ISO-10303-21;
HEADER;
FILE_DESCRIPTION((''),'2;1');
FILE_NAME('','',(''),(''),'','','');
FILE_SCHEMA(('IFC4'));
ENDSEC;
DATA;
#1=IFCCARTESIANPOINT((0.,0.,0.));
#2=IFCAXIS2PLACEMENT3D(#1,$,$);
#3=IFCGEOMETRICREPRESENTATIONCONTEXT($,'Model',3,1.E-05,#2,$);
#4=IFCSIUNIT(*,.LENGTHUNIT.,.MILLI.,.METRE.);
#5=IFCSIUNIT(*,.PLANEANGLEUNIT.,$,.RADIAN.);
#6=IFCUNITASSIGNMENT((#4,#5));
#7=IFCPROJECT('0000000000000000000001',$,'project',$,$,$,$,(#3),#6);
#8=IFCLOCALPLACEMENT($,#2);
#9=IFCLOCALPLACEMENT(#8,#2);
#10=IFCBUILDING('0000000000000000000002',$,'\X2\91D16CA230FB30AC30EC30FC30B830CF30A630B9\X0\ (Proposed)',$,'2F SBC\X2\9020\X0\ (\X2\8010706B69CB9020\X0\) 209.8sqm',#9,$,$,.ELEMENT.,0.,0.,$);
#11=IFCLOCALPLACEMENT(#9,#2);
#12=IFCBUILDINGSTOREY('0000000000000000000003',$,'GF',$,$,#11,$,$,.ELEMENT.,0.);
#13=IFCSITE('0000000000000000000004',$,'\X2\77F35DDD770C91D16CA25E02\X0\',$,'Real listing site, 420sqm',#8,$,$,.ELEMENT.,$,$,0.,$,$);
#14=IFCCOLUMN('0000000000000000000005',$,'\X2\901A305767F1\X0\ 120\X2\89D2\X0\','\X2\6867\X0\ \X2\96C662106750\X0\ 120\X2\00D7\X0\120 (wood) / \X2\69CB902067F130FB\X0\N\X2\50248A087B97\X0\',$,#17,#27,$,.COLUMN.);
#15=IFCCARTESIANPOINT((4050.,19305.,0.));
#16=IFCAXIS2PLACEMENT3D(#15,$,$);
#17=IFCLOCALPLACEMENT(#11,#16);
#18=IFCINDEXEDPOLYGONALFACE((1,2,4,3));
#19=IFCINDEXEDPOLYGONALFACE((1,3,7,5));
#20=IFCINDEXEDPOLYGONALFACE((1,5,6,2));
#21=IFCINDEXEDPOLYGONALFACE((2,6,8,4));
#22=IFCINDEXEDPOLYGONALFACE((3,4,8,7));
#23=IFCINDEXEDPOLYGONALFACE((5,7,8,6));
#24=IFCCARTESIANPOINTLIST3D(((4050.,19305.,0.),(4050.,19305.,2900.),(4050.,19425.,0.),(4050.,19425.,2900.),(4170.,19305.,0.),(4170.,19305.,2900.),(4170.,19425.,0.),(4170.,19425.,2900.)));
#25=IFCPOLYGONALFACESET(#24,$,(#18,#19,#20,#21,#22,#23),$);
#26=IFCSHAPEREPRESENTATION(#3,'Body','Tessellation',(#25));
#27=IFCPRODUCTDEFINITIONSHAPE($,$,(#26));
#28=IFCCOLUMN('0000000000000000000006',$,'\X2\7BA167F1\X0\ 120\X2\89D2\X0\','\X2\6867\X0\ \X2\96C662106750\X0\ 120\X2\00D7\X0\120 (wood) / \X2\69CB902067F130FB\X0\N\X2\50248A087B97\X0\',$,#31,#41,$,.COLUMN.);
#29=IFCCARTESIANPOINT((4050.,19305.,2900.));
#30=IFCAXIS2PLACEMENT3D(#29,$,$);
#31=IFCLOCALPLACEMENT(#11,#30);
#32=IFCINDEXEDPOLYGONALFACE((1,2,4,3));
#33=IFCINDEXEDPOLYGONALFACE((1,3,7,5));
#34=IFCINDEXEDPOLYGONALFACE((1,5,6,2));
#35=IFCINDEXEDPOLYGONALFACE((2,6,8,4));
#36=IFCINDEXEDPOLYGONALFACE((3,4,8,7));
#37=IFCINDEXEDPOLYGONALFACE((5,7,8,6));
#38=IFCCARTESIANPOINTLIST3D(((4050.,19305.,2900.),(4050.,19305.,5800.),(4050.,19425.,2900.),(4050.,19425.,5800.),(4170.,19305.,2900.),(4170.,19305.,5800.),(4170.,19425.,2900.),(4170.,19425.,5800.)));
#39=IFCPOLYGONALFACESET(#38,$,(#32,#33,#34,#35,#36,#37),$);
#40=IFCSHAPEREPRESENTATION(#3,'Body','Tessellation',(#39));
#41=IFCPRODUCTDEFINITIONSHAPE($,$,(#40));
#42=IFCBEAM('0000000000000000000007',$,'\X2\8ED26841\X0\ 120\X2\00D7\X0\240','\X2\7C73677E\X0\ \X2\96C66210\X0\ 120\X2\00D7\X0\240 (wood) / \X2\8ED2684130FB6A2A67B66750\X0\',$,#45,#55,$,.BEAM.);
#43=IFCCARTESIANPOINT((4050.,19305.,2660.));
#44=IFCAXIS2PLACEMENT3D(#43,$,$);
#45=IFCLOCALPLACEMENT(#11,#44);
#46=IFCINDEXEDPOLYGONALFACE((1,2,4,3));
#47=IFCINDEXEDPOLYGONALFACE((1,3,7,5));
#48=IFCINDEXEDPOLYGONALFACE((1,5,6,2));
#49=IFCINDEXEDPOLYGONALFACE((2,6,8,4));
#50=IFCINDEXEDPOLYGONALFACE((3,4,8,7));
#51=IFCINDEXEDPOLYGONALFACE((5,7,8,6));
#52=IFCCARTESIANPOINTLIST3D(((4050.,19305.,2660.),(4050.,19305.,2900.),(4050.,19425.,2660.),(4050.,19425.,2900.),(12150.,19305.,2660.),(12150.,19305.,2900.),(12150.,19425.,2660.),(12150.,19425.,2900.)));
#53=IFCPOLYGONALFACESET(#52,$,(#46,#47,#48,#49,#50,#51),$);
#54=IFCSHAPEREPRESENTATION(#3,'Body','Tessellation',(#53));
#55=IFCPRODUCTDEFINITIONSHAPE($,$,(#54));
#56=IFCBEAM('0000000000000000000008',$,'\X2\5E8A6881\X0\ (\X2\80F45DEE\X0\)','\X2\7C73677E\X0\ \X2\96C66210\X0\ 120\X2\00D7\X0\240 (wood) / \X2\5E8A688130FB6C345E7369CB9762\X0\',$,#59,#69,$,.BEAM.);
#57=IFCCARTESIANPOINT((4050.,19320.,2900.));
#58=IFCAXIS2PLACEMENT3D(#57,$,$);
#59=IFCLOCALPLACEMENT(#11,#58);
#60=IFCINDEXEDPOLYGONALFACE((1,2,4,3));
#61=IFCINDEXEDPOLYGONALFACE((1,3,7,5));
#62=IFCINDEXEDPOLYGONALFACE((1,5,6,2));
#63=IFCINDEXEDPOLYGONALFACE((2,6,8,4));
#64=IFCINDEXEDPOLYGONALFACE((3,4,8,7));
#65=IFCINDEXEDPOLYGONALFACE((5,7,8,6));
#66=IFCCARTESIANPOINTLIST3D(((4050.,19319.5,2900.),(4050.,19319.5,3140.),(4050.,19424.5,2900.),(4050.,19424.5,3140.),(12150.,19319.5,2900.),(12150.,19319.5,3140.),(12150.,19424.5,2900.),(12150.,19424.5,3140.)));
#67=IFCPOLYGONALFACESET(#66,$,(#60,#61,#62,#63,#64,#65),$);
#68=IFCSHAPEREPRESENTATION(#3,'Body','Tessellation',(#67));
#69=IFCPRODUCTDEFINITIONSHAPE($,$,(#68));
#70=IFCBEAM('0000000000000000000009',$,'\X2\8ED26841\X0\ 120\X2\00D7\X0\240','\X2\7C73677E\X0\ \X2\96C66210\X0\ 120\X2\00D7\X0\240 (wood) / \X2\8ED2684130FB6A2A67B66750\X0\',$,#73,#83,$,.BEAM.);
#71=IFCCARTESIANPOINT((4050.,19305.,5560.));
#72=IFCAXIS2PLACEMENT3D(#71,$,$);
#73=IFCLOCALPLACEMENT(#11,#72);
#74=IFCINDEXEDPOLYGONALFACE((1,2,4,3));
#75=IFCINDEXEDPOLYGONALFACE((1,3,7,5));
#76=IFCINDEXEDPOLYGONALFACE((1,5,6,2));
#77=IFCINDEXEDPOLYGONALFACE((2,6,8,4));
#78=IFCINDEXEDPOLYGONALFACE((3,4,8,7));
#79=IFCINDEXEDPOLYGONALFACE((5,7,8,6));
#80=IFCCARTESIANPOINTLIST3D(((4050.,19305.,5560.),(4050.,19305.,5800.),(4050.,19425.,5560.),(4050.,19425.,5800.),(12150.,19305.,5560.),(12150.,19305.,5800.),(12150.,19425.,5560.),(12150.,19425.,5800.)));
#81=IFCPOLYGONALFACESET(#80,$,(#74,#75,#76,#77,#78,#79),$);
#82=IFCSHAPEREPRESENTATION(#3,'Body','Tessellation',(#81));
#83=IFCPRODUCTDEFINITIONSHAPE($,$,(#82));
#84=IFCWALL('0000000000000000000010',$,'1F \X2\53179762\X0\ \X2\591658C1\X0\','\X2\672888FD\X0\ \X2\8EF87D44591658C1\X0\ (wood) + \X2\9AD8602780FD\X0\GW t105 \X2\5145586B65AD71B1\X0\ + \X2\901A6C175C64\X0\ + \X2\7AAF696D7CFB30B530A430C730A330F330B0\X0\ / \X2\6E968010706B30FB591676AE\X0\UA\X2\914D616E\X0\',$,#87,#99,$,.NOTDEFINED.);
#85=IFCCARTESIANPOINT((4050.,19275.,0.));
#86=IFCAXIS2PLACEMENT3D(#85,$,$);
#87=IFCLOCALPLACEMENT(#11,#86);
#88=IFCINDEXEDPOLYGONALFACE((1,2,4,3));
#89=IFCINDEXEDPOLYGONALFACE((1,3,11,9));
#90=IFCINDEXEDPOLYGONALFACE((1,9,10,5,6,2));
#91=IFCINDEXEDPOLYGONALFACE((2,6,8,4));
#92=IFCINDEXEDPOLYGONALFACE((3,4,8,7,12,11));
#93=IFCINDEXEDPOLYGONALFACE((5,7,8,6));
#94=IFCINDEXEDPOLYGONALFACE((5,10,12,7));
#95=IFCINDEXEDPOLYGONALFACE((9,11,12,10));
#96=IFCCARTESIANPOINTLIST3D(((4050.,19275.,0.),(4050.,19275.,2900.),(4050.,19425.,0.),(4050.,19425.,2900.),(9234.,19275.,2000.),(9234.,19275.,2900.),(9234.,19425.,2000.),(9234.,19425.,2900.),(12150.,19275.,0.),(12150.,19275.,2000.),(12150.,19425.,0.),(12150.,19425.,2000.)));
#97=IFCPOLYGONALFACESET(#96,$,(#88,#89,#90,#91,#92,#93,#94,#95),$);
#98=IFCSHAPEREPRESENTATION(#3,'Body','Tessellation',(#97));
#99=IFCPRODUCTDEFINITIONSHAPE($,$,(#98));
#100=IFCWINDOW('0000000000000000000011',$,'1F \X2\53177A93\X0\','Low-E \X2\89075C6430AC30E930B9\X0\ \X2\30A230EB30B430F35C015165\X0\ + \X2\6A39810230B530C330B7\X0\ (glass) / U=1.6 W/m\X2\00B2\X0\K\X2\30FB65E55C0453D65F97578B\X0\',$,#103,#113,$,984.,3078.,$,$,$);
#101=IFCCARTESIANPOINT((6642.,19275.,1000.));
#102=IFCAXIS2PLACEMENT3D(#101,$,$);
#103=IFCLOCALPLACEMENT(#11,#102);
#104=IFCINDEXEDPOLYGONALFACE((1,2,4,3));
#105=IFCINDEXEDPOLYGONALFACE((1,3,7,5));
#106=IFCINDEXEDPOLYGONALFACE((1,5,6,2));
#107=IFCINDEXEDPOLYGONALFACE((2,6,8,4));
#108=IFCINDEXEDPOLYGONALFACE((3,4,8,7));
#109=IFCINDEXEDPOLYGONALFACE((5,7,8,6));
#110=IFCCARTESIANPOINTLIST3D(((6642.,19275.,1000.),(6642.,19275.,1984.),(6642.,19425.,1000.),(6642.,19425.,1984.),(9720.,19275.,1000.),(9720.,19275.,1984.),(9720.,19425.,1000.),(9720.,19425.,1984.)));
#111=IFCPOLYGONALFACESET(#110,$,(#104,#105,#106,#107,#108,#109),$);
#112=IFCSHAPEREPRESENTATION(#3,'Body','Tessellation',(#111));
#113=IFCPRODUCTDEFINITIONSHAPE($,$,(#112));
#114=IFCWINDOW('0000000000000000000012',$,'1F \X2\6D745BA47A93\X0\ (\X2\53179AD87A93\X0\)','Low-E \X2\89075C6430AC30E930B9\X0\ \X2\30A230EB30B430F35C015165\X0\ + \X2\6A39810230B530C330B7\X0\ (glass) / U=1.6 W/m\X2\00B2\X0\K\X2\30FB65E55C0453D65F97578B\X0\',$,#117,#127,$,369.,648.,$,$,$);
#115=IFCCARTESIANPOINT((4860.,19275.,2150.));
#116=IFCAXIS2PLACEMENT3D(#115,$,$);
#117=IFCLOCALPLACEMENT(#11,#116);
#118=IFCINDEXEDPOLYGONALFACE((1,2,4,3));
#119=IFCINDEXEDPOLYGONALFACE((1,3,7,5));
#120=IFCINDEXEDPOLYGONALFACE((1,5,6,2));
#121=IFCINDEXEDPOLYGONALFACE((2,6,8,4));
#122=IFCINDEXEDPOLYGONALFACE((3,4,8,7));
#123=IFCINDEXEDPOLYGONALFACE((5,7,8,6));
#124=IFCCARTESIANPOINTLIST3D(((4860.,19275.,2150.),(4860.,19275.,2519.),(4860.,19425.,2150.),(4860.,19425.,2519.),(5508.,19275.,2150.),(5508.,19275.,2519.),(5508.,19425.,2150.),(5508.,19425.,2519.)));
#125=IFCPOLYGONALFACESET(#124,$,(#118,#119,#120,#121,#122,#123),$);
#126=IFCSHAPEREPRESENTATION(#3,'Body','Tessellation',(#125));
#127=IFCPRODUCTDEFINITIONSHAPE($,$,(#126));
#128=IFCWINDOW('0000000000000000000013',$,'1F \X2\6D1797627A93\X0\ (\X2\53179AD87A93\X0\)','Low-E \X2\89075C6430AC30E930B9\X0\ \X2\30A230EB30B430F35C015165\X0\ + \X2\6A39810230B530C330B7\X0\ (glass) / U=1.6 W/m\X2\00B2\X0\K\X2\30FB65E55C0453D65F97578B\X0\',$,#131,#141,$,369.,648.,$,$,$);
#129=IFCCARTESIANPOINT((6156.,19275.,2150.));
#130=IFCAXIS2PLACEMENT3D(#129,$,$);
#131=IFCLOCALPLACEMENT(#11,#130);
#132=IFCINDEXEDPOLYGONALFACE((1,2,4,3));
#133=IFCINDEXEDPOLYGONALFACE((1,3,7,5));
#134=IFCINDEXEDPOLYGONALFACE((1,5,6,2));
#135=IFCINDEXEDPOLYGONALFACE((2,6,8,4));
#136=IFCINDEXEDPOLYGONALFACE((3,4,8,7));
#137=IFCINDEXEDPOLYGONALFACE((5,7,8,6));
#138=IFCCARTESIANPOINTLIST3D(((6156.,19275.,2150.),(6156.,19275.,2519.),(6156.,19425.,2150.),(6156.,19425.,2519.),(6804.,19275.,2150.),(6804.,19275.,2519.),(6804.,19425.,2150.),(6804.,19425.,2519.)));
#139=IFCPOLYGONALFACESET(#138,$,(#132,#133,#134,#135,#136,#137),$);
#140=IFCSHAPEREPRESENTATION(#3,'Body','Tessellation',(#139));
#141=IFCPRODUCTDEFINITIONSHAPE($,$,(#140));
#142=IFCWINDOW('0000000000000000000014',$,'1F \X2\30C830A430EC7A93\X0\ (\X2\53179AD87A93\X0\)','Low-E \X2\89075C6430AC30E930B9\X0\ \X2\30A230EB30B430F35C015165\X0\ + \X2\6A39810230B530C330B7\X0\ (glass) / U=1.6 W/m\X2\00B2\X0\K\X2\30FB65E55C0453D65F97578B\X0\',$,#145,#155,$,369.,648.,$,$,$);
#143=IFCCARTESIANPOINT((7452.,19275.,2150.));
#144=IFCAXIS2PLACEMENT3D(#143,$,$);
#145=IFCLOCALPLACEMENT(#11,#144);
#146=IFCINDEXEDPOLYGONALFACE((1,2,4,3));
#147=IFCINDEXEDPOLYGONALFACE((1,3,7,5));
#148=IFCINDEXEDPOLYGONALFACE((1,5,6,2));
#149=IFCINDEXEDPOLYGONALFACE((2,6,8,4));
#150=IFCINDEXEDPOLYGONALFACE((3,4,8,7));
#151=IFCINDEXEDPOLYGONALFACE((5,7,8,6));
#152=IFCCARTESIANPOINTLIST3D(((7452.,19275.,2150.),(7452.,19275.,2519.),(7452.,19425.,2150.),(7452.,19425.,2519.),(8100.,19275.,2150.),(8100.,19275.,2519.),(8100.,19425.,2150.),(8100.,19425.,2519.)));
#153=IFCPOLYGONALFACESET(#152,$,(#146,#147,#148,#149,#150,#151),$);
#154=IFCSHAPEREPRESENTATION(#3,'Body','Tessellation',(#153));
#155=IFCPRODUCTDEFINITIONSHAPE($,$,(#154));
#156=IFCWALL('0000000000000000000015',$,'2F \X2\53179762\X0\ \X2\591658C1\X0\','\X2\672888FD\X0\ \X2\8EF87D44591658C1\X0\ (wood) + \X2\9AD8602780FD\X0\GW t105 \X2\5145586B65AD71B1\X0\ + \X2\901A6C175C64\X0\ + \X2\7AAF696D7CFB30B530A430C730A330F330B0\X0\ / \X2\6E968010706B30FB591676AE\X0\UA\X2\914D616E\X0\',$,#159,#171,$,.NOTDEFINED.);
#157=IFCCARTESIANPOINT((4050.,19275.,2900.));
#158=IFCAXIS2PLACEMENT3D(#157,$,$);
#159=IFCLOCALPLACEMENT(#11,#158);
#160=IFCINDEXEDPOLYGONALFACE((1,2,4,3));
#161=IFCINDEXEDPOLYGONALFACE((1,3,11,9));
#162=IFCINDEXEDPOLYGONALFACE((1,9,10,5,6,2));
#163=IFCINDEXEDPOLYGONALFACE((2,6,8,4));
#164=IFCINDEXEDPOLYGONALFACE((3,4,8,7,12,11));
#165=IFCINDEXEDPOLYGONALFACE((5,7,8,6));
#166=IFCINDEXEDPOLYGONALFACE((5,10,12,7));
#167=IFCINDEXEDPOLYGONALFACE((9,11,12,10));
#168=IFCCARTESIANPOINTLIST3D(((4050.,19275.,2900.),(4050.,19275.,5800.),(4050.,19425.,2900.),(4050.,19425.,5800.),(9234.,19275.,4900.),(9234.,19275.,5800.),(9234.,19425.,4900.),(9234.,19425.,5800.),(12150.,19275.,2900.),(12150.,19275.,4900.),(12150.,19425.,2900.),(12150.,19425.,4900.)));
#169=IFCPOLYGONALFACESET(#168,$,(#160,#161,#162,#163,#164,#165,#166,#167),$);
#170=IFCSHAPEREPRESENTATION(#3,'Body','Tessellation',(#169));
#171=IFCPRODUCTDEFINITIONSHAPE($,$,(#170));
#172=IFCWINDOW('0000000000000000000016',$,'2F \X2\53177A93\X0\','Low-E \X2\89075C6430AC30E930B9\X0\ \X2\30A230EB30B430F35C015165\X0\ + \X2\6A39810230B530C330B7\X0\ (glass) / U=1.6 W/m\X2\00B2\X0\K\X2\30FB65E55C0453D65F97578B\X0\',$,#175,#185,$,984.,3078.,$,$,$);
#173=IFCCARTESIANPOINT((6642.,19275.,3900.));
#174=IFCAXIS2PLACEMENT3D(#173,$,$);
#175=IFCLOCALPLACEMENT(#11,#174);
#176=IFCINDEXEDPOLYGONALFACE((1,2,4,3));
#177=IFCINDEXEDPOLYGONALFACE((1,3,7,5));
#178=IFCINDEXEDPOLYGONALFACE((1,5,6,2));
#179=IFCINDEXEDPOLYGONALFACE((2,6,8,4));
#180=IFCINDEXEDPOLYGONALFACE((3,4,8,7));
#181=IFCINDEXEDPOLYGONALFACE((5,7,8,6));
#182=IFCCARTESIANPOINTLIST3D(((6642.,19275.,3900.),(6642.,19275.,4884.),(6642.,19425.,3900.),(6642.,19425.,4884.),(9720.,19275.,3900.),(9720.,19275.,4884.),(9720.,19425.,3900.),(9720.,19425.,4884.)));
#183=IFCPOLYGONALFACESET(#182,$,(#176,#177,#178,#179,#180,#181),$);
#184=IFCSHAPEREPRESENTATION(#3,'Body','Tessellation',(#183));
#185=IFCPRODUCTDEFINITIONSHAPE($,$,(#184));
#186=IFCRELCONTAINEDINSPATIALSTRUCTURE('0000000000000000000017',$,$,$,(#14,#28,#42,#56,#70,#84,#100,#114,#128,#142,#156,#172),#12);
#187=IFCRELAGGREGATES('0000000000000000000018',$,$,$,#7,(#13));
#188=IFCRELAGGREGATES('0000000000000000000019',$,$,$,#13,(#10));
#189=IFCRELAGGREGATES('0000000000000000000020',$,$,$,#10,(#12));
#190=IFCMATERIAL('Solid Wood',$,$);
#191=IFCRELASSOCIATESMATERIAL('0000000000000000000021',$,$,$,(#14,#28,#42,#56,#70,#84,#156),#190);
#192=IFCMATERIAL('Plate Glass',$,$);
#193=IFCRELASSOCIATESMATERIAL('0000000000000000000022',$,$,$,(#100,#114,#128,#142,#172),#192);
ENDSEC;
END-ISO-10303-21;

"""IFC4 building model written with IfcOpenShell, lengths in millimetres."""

from ifc_helpers import new_model, si_unit, frame, frame_2d, origin, place, context, project, spatial, rectangle, extrude, material, element, fill, save


model = new_model("IFC4")

# Units and contexts
model_context = context("Model", 3, precision=1e-05, world=origin())
ifc_project = project(units=[si_unit("LENGTHUNIT", "METRE", prefix="MILLI"), si_unit("PLANEANGLEUNIT", "RADIAN")], contexts=[model_context])

# Site, building, storey
site_placement = place(None, origin())
site = spatial("IfcSite", under=ifc_project, at=site_placement, Name="石川県金沢市", ObjectType="Real listing site, 420sqm", CompositionType="ELEMENT", RefElevation=0.0)
building_placement = place(site_placement, origin())
building = spatial("IfcBuilding", under=site, at=building_placement, Name="金沢・ガレージハウス (Proposed)", ObjectType="2F SBC造 (耐火構造) 209.8sqm", CompositionType="ELEMENT", ElevationOfRefHeight=0.0, ElevationOfTerrain=0.0)
storey_placement = place(building_placement, origin())
storey = spatial("IfcBuildingStorey", under=building, at=storey_placement, Name="GF", CompositionType="ELEMENT", Elevation=0.0)

# Columns
ifc_material_1 = material(Name="Solid Wood")
column_1_placement = place(storey_placement, frame((4050.0, 19305.0, 0.0)))
element("IfcColumn", 1, at=column_1_placement, inside=storey, material=ifc_material_1, Name="通し柱 120角", Description="桧 集成材 120×120 (wood) / 構造柱・N値計算", PredefinedType="COLUMN", context=model_context, shape_type="SweptSolid", body=[
    extrude(rectangle(XDim=120.0, YDim=120.0, at=frame_2d((60.0, 60.0))), frame((4050.0, 19305.0, 0.0)), (0.0, 0.0, 1.0), 2900.0),
])
column_2_placement = place(storey_placement, frame((4050.0, 19305.0, 2900.0)))
element("IfcColumn", 2, at=column_2_placement, inside=storey, material=ifc_material_1, Name="管柱 120角", Description="桧 集成材 120×120 (wood) / 構造柱・N値計算", PredefinedType="COLUMN", context=model_context, shape_type="SweptSolid", body=[
    extrude(rectangle(XDim=120.0, YDim=120.0, at=frame_2d((60.0, 60.0))), frame((4050.0, 19305.0, 2900.0)), (0.0, 0.0, 1.0), 2900.0),
])

# Beams
beam_1_placement = place(storey_placement, frame((4050.0, 19305.0, 2660.0)))
element("IfcBeam", 3, at=beam_1_placement, inside=storey, material=ifc_material_1, Name="軒桁 120×240", Description="米松 集成 120×240 (wood) / 軒桁・横架材", PredefinedType="BEAM", context=model_context, shape_type="SweptSolid", body=[
    extrude(rectangle(XDim=8100.0, YDim=120.0, at=frame_2d((4050.0, 60.0))), frame((4050.0, 19305.0, 2660.0)), (0.0, 0.0, 1.0), 240.0),
])
beam_2_placement = place(storey_placement, frame((4050.0, 19320.0, 2900.0)))
element("IfcBeam", 4, at=beam_2_placement, inside=storey, material=ifc_material_1, Name="床梁 (胴差)", Description="米松 集成 120×240 (wood) / 床梁・水平構面", PredefinedType="BEAM", context=model_context, shape_type="SweptSolid", body=[
    extrude(rectangle(XDim=8100.0, YDim=105.0, at=frame_2d((4050.0, 52.0))), frame((4050.0, 19320.0, 2900.0)), (0.0, 0.0, 1.0), 240.0),
])
beam_3_placement = place(storey_placement, frame((4050.0, 19305.0, 5560.0)))
element("IfcBeam", 5, at=beam_3_placement, inside=storey, material=ifc_material_1, Name="軒桁 120×240", Description="米松 集成 120×240 (wood) / 軒桁・横架材", PredefinedType="BEAM", context=model_context, shape_type="SweptSolid", body=[
    extrude(rectangle(XDim=8100.0, YDim=120.0, at=frame_2d((4050.0, 60.0))), frame((4050.0, 19305.0, 5560.0)), (0.0, 0.0, 1.0), 240.0),
])

# Wall, openings, windows
wall_1_placement = place(storey_placement, frame((4050.0, 19275.0, 0.0)))
wall_1 = element("IfcWall", 6, at=wall_1_placement, inside=storey, material=ifc_material_1, Name="1F 北面 外壁", Description="木製 軸組外壁 (wood) + 高性能GW t105 充填断熱 + 通気層 + 窯業系サイディング / 準耐火・外皮UA配慮", PredefinedType="NOTDEFINED", context=model_context, shape_type="SweptSolid", body=[
    extrude(rectangle(XDim=8100.0, YDim=150.0, at=frame_2d((4050.0, 75.0))), frame((4050.0, 19275.0, 0.0)), (0.0, 0.0, 1.0), 2900.0),
])
opening_1_placement = place(storey_placement, frame((6642.0, 19275.0, 1000.0)))
opening_1 = element("IfcOpeningElement", 7, at=opening_1_placement, cuts=wall_1, PredefinedType="NOTDEFINED", context=model_context, shape_type="SweptSolid", body=[
    extrude(rectangle(XDim=3078.0, YDim=150.0, at=frame_2d((1539.0, 75.0))), frame((6642.0, 19275.0, 1000.0)), (0.0, 0.0, 1.0), 984.0),
])
opening_2_placement = place(storey_placement, frame((4860.0, 19275.0, 2150.0)))
opening_2 = element("IfcOpeningElement", 8, at=opening_2_placement, cuts=wall_1, PredefinedType="NOTDEFINED", context=model_context, shape_type="SweptSolid", body=[
    extrude(rectangle(XDim=648.0, YDim=150.0, at=frame_2d((324.0, 75.0))), frame((4860.0, 19275.0, 2150.0)), (0.0, 0.0, 1.0), 369.0),
])
opening_3_placement = place(storey_placement, frame((6156.0, 19275.0, 2150.0)))
opening_3 = element("IfcOpeningElement", 9, at=opening_3_placement, cuts=wall_1, PredefinedType="NOTDEFINED", context=model_context, shape_type="SweptSolid", body=[
    extrude(rectangle(XDim=648.0, YDim=150.0, at=frame_2d((324.0, 75.0))), frame((6156.0, 19275.0, 2150.0)), (0.0, 0.0, 1.0), 369.0),
])
opening_4_placement = place(storey_placement, frame((7452.0, 19275.0, 2150.0)))
opening_4 = element("IfcOpeningElement", 10, at=opening_4_placement, cuts=wall_1, PredefinedType="NOTDEFINED", context=model_context, shape_type="SweptSolid", body=[
    extrude(rectangle(XDim=648.0, YDim=150.0, at=frame_2d((324.0, 75.0))), frame((7452.0, 19275.0, 2150.0)), (0.0, 0.0, 1.0), 369.0),
])
ifc_material_2 = material(Name="Plate Glass")
window_1_placement = place(storey_placement, frame((6642.0, 19275.0, 1000.0)))
window_1 = element("IfcWindow", 11, at=window_1_placement, inside=storey, material=ifc_material_2, Name="1F 北窓", Description="Low-E 複層ガラス アルゴン封入 + 樹脂サッシ (glass) / U=1.6 W/m²K・日射取得型", OverallHeight=984.0, OverallWidth=3078.0, context=model_context, shape_type="SweptSolid", body=[
    extrude(rectangle(XDim=3078.0, YDim=150.0, at=frame_2d((1539.0, 75.0))), frame((6642.0, 19275.0, 1000.0)), (0.0, 0.0, 1.0), 984.0),
])
fill(opening_1, window_1)
window_2_placement = place(storey_placement, frame((4860.0, 19275.0, 2150.0)))
window_2 = element("IfcWindow", 12, at=window_2_placement, inside=storey, material=ifc_material_2, Name="1F 浴室窓 (北高窓)", Description="Low-E 複層ガラス アルゴン封入 + 樹脂サッシ (glass) / U=1.6 W/m²K・日射取得型", OverallHeight=369.0, OverallWidth=648.0, context=model_context, shape_type="SweptSolid", body=[
    extrude(rectangle(XDim=648.0, YDim=150.0, at=frame_2d((324.0, 75.0))), frame((4860.0, 19275.0, 2150.0)), (0.0, 0.0, 1.0), 369.0),
])
fill(opening_2, window_2)
window_3_placement = place(storey_placement, frame((6156.0, 19275.0, 2150.0)))
window_3 = element("IfcWindow", 13, at=window_3_placement, inside=storey, material=ifc_material_2, Name="1F 洗面窓 (北高窓)", Description="Low-E 複層ガラス アルゴン封入 + 樹脂サッシ (glass) / U=1.6 W/m²K・日射取得型", OverallHeight=369.0, OverallWidth=648.0, context=model_context, shape_type="SweptSolid", body=[
    extrude(rectangle(XDim=648.0, YDim=150.0, at=frame_2d((324.0, 75.0))), frame((6156.0, 19275.0, 2150.0)), (0.0, 0.0, 1.0), 369.0),
])
fill(opening_3, window_3)
window_4_placement = place(storey_placement, frame((7452.0, 19275.0, 2150.0)))
window_4 = element("IfcWindow", 14, at=window_4_placement, inside=storey, material=ifc_material_2, Name="1F トイレ窓 (北高窓)", Description="Low-E 複層ガラス アルゴン封入 + 樹脂サッシ (glass) / U=1.6 W/m²K・日射取得型", OverallHeight=369.0, OverallWidth=648.0, context=model_context, shape_type="SweptSolid", body=[
    extrude(rectangle(XDim=648.0, YDim=150.0, at=frame_2d((324.0, 75.0))), frame((7452.0, 19275.0, 2150.0)), (0.0, 0.0, 1.0), 369.0),
])
fill(opening_4, window_4)

# Wall, opening, window
wall_2_placement = place(storey_placement, frame((4050.0, 19275.0, 2900.0)))
wall_2 = element("IfcWall", 15, at=wall_2_placement, inside=storey, material=ifc_material_1, Name="2F 北面 外壁", Description="木製 軸組外壁 (wood) + 高性能GW t105 充填断熱 + 通気層 + 窯業系サイディング / 準耐火・外皮UA配慮", PredefinedType="NOTDEFINED", context=model_context, shape_type="SweptSolid", body=[
    extrude(rectangle(XDim=8100.0, YDim=150.0, at=frame_2d((4050.0, 75.0))), frame((4050.0, 19275.0, 2900.0)), (0.0, 0.0, 1.0), 2900.0),
])
opening_5_placement = place(storey_placement, frame((6642.0, 19275.0, 3900.0)))
opening_5 = element("IfcOpeningElement", 16, at=opening_5_placement, cuts=wall_2, PredefinedType="NOTDEFINED", context=model_context, shape_type="SweptSolid", body=[
    extrude(rectangle(XDim=3078.0, YDim=150.0, at=frame_2d((1539.0, 75.0))), frame((6642.0, 19275.0, 3900.0)), (0.0, 0.0, 1.0), 984.0),
])
window_5_placement = place(storey_placement, frame((6642.0, 19275.0, 3900.0)))
window_5 = element("IfcWindow", 17, at=window_5_placement, inside=storey, material=ifc_material_2, Name="2F 北窓", Description="Low-E 複層ガラス アルゴン封入 + 樹脂サッシ (glass) / U=1.6 W/m²K・日射取得型", OverallHeight=984.0, OverallWidth=3078.0, context=model_context, shape_type="SweptSolid", body=[
    extrude(rectangle(XDim=3078.0, YDim=150.0, at=frame_2d((1539.0, 75.0))), frame((6642.0, 19275.0, 3900.0)), (0.0, 0.0, 1.0), 984.0),
])
fill(opening_5, window_5)

save(model, "model.ifc")
